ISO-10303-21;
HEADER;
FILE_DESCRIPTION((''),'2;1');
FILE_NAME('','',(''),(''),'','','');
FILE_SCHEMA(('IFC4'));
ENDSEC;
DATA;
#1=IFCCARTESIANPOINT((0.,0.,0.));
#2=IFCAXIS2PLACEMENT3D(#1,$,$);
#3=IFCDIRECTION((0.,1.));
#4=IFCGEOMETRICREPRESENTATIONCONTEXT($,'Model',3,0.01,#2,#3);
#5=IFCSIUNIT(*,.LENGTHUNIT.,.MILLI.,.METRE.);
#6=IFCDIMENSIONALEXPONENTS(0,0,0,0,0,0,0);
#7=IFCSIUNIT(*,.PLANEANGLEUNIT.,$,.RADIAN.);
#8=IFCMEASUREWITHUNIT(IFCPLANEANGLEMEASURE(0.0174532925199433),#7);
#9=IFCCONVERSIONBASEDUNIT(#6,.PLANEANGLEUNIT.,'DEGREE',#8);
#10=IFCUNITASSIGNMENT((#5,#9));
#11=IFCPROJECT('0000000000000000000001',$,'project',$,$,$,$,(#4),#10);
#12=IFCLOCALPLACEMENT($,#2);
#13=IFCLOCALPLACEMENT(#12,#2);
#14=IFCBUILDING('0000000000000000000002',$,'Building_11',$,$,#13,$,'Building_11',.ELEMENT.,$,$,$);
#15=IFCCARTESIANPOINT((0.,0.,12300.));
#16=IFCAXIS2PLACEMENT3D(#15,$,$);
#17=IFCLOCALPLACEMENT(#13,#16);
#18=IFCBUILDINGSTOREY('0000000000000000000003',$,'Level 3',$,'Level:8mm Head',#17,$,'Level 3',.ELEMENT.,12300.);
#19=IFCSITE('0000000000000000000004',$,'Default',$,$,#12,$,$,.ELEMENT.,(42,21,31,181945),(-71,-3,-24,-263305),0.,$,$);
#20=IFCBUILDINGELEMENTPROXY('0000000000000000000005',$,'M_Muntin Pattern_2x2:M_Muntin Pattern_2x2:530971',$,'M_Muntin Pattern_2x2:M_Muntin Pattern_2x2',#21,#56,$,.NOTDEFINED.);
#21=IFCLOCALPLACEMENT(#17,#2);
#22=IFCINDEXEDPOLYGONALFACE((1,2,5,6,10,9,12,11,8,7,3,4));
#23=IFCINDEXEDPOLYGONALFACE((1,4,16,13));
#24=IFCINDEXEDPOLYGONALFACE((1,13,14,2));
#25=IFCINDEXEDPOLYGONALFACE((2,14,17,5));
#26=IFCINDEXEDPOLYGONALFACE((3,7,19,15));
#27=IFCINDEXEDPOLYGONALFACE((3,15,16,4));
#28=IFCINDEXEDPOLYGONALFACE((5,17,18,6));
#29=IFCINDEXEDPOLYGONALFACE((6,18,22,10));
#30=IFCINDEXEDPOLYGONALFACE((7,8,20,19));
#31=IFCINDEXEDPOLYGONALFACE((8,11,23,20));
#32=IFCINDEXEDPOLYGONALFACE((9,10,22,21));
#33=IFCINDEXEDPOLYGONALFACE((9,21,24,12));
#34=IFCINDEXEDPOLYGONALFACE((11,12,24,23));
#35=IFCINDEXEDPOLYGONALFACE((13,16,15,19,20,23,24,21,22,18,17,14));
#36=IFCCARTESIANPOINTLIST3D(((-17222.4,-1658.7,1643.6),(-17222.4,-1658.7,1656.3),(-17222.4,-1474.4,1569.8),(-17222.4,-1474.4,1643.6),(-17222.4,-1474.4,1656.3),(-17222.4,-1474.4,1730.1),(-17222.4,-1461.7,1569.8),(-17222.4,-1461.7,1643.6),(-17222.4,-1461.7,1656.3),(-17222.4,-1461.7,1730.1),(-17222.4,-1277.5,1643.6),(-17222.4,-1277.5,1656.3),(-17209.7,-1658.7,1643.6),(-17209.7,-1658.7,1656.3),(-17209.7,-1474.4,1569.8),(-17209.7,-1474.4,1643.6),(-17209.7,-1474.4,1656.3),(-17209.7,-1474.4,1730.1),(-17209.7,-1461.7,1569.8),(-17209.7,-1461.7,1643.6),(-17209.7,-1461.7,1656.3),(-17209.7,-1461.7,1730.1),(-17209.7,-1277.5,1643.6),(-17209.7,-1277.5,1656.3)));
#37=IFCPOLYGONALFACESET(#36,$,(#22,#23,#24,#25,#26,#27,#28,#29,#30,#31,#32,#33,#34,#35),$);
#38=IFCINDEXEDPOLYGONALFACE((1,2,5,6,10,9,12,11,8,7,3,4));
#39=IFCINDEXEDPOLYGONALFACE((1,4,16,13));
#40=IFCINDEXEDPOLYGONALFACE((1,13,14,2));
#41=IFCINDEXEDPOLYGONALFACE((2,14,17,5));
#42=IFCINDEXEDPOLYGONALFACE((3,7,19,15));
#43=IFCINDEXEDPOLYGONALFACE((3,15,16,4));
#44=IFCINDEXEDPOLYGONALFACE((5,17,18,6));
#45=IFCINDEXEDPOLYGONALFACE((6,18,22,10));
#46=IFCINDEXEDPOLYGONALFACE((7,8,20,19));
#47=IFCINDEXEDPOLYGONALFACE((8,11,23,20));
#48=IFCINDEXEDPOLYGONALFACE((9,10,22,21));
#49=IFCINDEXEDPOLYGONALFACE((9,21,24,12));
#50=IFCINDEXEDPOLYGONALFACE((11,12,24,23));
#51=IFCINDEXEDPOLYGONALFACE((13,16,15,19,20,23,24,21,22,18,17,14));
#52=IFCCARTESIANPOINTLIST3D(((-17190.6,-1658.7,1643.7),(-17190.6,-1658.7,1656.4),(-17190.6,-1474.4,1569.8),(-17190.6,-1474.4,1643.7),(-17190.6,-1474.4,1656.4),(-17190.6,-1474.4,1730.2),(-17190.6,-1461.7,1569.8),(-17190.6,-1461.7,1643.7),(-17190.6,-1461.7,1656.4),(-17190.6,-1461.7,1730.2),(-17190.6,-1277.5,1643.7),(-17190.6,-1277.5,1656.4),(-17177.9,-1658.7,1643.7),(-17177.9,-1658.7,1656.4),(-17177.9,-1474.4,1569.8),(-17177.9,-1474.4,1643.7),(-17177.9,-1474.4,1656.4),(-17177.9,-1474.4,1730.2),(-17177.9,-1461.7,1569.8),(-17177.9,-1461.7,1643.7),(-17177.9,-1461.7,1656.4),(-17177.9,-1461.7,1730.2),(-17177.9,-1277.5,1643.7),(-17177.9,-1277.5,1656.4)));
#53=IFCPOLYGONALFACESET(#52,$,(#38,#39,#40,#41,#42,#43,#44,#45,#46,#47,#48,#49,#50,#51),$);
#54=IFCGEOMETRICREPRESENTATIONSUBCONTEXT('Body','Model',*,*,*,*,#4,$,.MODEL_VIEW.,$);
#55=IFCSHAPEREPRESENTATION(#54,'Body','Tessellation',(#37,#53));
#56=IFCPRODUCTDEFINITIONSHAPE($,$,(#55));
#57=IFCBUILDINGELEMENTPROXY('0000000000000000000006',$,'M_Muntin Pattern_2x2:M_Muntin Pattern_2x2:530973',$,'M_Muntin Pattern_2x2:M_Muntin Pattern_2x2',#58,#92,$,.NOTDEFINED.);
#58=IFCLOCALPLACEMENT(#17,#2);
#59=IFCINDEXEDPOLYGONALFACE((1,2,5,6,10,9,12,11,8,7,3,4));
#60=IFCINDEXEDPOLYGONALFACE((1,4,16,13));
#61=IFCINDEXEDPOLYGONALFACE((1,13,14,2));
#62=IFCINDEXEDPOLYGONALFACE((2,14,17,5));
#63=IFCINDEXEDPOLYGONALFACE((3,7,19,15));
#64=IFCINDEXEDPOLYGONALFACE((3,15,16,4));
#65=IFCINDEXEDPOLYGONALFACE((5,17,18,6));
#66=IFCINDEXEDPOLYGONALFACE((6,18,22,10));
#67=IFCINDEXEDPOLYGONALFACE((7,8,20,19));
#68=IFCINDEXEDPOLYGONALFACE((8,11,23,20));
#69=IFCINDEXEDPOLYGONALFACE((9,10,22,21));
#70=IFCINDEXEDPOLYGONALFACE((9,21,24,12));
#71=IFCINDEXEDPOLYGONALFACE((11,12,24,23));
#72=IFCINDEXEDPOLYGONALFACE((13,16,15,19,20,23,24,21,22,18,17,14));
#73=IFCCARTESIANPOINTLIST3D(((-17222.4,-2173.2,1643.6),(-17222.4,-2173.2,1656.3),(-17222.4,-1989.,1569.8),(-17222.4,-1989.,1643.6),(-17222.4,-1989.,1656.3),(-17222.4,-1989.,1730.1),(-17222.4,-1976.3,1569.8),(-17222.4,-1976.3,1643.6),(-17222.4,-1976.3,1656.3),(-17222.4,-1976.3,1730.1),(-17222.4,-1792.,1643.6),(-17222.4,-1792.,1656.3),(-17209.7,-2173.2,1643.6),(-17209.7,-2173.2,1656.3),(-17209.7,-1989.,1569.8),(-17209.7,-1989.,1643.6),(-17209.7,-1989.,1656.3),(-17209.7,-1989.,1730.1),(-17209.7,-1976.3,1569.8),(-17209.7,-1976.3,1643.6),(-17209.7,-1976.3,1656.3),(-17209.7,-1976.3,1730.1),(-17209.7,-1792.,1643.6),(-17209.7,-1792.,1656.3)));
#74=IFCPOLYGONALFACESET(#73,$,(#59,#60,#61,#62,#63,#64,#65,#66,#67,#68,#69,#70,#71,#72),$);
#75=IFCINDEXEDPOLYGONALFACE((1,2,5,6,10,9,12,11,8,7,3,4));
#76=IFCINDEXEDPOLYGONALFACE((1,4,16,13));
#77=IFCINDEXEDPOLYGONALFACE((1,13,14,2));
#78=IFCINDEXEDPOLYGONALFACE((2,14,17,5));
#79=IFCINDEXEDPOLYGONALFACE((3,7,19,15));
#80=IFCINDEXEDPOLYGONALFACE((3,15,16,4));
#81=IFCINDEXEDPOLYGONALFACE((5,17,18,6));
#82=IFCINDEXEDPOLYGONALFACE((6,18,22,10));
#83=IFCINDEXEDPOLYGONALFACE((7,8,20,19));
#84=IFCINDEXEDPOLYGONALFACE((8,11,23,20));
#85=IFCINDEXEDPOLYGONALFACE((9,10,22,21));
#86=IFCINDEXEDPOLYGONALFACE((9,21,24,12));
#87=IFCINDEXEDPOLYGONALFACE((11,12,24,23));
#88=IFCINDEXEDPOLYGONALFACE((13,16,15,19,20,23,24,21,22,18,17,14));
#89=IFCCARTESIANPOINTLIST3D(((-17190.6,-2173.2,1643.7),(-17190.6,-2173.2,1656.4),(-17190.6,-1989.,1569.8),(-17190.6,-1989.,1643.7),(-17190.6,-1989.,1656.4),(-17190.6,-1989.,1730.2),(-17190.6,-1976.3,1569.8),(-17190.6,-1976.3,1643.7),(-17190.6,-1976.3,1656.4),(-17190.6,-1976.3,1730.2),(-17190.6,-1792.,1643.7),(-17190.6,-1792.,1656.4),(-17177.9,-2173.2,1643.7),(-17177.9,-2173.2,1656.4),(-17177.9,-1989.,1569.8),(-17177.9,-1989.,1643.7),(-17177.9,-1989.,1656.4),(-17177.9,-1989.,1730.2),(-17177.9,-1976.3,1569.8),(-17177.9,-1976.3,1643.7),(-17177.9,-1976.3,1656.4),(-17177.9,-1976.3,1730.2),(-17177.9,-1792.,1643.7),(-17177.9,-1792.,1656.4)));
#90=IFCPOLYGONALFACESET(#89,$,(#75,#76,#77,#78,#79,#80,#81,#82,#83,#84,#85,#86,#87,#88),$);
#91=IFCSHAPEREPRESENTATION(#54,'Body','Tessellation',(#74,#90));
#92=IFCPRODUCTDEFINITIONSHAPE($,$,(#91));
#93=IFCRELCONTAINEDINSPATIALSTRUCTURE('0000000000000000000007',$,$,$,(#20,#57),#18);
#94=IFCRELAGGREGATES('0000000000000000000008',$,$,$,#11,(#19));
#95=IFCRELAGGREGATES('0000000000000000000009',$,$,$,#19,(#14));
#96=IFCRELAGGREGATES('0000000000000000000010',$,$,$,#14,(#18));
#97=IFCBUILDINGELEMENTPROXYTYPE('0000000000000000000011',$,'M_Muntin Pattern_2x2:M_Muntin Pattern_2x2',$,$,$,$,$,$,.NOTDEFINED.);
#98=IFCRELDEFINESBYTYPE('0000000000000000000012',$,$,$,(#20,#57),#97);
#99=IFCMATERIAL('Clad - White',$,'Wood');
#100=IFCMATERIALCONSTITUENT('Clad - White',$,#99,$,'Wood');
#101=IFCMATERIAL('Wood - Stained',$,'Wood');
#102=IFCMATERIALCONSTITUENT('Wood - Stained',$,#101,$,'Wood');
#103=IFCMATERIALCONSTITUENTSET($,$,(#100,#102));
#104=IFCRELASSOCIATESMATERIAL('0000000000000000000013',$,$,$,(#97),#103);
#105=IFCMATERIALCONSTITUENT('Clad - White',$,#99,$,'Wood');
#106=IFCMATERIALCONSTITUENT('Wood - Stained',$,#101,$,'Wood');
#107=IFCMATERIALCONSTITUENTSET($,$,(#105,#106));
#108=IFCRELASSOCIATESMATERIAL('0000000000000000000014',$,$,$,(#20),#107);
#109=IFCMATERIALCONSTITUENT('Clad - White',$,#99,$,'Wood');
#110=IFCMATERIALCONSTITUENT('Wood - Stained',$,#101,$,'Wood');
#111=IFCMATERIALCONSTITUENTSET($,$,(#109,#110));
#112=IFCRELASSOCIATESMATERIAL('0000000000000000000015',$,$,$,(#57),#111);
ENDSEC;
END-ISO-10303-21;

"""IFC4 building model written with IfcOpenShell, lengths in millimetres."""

from ifc_helpers import new_model, entity, si_unit, converted_unit, direction, frame, origin, place, context, subcontext, project, spatial, indexed_curve, outline, extrude, source, transform, mapped, material, constituent, constituent_set, type_object, type_shapes, element, save


model = new_model("IFC4")

# Units and contexts
model_context = context("Model", 3, precision=0.01, world=origin(), true_north=direction((0.0, 1.0)))
body_context = subcontext(model_context, "Body", "Model", "MODEL_VIEW")
ifc_project = project(units=[si_unit("LENGTHUNIT", "METRE", prefix="MILLI"), converted_unit("PLANEANGLEUNIT", "DEGREE", entity("IfcPlaneAngleMeasure", 0.0174532925199433), si_unit("PLANEANGLEUNIT", "RADIAN"), dimensions=[0, 0, 0, 0, 0, 0, 0])], contexts=[model_context])

# Site, building, storey
site_placement = place(None, origin())
site = spatial("IfcSite", under=ifc_project, at=site_placement, Name="Default", CompositionType="ELEMENT", RefLatitude=(42, 21, 31, 181945), RefLongitude=(-71, -3, -24, -263305), RefElevation=0.0)
building_placement = place(site_placement, origin())
building = spatial("IfcBuilding", under=site, at=building_placement, Name="Building_11", LongName="Building_11", CompositionType="ELEMENT")
storey_placement = place(building_placement, frame((0.0, 0.0, 12300.0)))
storey = spatial("IfcBuildingStorey", under=building, at=storey_placement, Name="Level 3", ObjectType="Level:8mm Head", LongName="Level 3", CompositionType="ELEMENT", Elevation=12300.0)

# Building element proxies
ifc_material_1 = material(Name="Clad - White", Category="Wood")
ifc_material_2 = material(Name="Wood - Stained", Category="Wood")
ifc_constituent_1 = constituent(ifc_material_1, Name="Clad - White", Category="Wood")
ifc_constituent_2 = constituent(ifc_material_2, Name="Wood - Stained", Category="Wood")
ifc_constituent_set_1 = constituent_set(constituents=[ifc_constituent_1, ifc_constituent_2])
building_element_proxy_type_1 = type_object("IfcBuildingElementProxyType", Name="M_Muntin Pattern_2x2:M_Muntin Pattern_2x2", PredefinedType="NOTDEFINED", material=ifc_constituent_set_1)
shared_shape_1 = source(origin(), body_context, "Body", "SweptSolid", [
    extrude(outline(indexed_curve([(6.4, -6.4), (80.1, -6.4), (80.1, 6.3), (6.4, 6.3), (6.4, 190.6), (-6.3, 190.6), (-6.3, 6.3), (-80.2, 6.3), (-80.2, -6.4), (-6.3, -6.4), (-6.3, -190.6), (6.4, -190.6), (6.4, -6.4)], self_intersect=False)), frame((0.0, 9.5, 80.1), z_axis=(0.0, 1.0, 0.0), x_axis=(0.0, 0.0, 1.0)), (0.0, 0.0, 1.0), 12.7),
    extrude(outline(indexed_curve([(6.4, -6.4), (80.2, -6.4), (80.2, 6.3), (6.4, 6.3), (6.4, 190.6), (-6.3, 190.6), (-6.3, 6.3), (-80.2, 6.3), (-80.2, -6.4), (-6.3, -6.4), (-6.3, -190.6), (6.4, -190.6), (6.4, -6.4)], self_intersect=False)), frame((0.0, -22.2, 80.2), z_axis=(0.0, 1.0, 0.0), x_axis=(0.0, 0.0, 1.0)), (0.0, 0.0, 1.0), 12.7),
])
type_shapes(building_element_proxy_type_1, [shared_shape_1])
ifc_constituent_3 = constituent(ifc_material_1, Name="Clad - White", Category="Wood")
ifc_constituent_4 = constituent(ifc_material_2, Name="Wood - Stained", Category="Wood")
ifc_constituent_set_2 = constituent_set(constituents=[ifc_constituent_3, ifc_constituent_4])
proxy_1_placement = place(storey_placement, frame((-17200.2, -1468.1, 1569.8), z_axis=(0.0, 0.0, 1.0), x_axis=(0.0, 1.0, 0.0)))
element("IfcBuildingElementProxy", 1, at=proxy_1_placement, inside=storey, type_object=building_element_proxy_type_1, material=ifc_constituent_set_2, Name="M_Muntin Pattern_2x2:M_Muntin Pattern_2x2:530971", ObjectType="M_Muntin Pattern_2x2:M_Muntin Pattern_2x2", PredefinedType="NOTDEFINED", context=body_context, shape_type="MappedRepresentation", body=[
    mapped(shared_shape_1, transform((0.0, 0.0, 0.0), scale=1.0)),
])
ifc_constituent_5 = constituent(ifc_material_1, Name="Clad - White", Category="Wood")
ifc_constituent_6 = constituent(ifc_material_2, Name="Wood - Stained", Category="Wood")
ifc_constituent_set_3 = constituent_set(constituents=[ifc_constituent_5, ifc_constituent_6])
proxy_2_placement = place(storey_placement, frame((-17200.2, -1982.6, 1569.8), z_axis=(0.0, 0.0, 1.0), x_axis=(0.0, 1.0, 0.0)))
element("IfcBuildingElementProxy", 2, at=proxy_2_placement, inside=storey, type_object=building_element_proxy_type_1, material=ifc_constituent_set_3, Name="M_Muntin Pattern_2x2:M_Muntin Pattern_2x2:530973", ObjectType="M_Muntin Pattern_2x2:M_Muntin Pattern_2x2", PredefinedType="NOTDEFINED", context=body_context, shape_type="MappedRepresentation", body=[
    mapped(shared_shape_1, transform((0.0, 0.0, 0.0), scale=1.0)),
])

save(model, "model.ifc")
